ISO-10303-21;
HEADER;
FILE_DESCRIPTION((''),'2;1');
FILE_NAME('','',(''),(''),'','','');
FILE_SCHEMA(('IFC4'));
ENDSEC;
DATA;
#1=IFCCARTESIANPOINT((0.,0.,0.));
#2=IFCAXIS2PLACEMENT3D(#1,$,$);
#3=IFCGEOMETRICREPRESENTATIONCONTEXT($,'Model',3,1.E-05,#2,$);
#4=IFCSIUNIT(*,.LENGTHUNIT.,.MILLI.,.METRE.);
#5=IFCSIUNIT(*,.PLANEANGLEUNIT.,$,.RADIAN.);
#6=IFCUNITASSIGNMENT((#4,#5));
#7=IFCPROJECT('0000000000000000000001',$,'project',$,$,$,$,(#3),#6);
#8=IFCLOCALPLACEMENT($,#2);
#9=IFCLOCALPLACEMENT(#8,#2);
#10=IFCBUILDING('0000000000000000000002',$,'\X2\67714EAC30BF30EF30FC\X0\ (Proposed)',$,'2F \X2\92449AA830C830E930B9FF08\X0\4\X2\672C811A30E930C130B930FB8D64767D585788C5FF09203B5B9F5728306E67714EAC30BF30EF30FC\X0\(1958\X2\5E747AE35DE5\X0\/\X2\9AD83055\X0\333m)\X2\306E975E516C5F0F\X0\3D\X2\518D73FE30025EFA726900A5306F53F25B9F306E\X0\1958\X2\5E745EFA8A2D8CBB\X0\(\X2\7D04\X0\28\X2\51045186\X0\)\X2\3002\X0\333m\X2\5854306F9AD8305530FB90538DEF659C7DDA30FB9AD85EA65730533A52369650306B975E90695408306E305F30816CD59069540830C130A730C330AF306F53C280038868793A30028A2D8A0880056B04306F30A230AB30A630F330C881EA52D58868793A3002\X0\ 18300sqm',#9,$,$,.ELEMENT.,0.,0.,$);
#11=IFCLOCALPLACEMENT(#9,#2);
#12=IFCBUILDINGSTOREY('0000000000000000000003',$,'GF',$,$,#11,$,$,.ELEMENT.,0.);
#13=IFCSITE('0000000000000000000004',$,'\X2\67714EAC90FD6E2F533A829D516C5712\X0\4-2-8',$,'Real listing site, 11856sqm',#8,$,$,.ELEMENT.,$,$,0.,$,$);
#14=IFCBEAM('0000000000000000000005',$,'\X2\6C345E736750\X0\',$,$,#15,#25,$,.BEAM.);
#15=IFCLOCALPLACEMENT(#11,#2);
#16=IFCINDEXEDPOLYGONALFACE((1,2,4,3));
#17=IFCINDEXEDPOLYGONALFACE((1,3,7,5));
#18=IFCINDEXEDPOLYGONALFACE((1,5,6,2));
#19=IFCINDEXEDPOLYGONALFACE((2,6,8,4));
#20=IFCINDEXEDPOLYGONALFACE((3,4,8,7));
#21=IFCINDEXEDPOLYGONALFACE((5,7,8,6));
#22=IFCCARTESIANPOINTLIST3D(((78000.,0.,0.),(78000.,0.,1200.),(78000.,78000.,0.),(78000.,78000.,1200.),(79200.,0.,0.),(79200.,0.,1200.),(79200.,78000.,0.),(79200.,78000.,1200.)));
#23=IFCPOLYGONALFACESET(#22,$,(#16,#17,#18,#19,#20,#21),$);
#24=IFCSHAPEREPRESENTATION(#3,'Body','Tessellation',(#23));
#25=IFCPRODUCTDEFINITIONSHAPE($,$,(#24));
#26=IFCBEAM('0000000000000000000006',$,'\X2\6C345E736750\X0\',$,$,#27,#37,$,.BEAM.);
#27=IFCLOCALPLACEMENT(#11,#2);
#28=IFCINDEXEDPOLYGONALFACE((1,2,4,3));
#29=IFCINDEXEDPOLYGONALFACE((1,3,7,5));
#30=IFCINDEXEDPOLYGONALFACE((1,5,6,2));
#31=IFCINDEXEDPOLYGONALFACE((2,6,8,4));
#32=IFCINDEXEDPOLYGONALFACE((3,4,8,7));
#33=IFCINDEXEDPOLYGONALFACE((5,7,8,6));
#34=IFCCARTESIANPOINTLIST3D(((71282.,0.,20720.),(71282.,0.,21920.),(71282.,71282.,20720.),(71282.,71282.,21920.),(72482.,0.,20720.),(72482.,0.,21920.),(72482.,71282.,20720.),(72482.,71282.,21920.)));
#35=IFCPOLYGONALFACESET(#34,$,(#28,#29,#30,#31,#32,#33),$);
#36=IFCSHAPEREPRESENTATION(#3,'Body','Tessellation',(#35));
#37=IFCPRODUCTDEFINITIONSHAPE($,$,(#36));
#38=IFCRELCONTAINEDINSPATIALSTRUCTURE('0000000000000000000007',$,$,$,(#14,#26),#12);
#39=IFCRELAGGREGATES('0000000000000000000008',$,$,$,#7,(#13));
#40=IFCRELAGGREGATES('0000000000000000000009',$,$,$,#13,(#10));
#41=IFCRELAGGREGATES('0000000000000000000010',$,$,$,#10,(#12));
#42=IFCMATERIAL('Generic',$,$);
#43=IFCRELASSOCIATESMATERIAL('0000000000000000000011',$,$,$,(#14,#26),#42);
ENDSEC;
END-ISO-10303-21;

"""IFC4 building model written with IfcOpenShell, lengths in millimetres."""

from ifc_helpers import new_model, si_unit, frame, frame_2d, origin, place, context, project, spatial, rectangle, extrude, material, element, save


model = new_model("IFC4")

# Units and contexts
model_context = context("Model", 3, precision=1e-05, world=origin())
ifc_project = project(units=[si_unit("LENGTHUNIT", "METRE", prefix="MILLI"), si_unit("PLANEANGLEUNIT", "RADIAN")], contexts=[model_context])

# Site, building, storey
site_placement = place(None, origin())
site = spatial("IfcSite", under=ifc_project, at=site_placement, Name="東京都港区芝公園4-2-8", ObjectType="Real listing site, 11856sqm", CompositionType="ELEMENT", RefElevation=0.0)
building_placement = place(site_placement, origin())
building = spatial("IfcBuilding", under=site, at=building_placement, Name="東京タワー (Proposed)", ObjectType="2F 鉄骨トラス（4本脚ラチス・赤白塗装）※実在の東京タワー(1958年竣工/高さ333m)の非公式3D再現。建物¥は史実の1958年建設費(約28億円)。333m塔は高さ・道路斜線・高度地区制限に非適合のため法適合チェックは参考表示。設計者欄はアカウント自動表示。 18300sqm", CompositionType="ELEMENT", ElevationOfRefHeight=0.0, ElevationOfTerrain=0.0)
storey_placement = place(building_placement, origin())
storey = spatial("IfcBuildingStorey", under=building, at=storey_placement, Name="GF", CompositionType="ELEMENT", Elevation=0.0)

# Shared definitions
ifc_material = material(Name="Generic")

# Beams
beam_1_placement = place(storey_placement, frame((39000.0, 0.0, 0.0)))
element("IfcBeam", 1, at=beam_1_placement, inside=storey, material=ifc_material, Name="水平材", PredefinedType="BEAM", context=model_context, shape_type="SweptSolid", body=[
    extrude(rectangle(XDim=1200.0, YDim=78000.0, at=frame_2d((600.0, 39000.0))), frame((39000.0, 0.0, 0.0)), (0.0, 0.0, 1.0), 1200.0),
])
beam_2_placement = place(storey_placement, frame((35641.0, 0.0, 10360.0)))
element("IfcBeam", 2, at=beam_2_placement, inside=storey, material=ifc_material, Name="水平材", PredefinedType="BEAM", context=model_context, shape_type="SweptSolid", body=[
    extrude(rectangle(XDim=1200.0, YDim=71282.0, at=frame_2d((600.0, 35641.0))), frame((35641.0, 0.0, 10360.0)), (0.0, 0.0, 1.0), 1200.0),
])

save(model, "model.ifc")
